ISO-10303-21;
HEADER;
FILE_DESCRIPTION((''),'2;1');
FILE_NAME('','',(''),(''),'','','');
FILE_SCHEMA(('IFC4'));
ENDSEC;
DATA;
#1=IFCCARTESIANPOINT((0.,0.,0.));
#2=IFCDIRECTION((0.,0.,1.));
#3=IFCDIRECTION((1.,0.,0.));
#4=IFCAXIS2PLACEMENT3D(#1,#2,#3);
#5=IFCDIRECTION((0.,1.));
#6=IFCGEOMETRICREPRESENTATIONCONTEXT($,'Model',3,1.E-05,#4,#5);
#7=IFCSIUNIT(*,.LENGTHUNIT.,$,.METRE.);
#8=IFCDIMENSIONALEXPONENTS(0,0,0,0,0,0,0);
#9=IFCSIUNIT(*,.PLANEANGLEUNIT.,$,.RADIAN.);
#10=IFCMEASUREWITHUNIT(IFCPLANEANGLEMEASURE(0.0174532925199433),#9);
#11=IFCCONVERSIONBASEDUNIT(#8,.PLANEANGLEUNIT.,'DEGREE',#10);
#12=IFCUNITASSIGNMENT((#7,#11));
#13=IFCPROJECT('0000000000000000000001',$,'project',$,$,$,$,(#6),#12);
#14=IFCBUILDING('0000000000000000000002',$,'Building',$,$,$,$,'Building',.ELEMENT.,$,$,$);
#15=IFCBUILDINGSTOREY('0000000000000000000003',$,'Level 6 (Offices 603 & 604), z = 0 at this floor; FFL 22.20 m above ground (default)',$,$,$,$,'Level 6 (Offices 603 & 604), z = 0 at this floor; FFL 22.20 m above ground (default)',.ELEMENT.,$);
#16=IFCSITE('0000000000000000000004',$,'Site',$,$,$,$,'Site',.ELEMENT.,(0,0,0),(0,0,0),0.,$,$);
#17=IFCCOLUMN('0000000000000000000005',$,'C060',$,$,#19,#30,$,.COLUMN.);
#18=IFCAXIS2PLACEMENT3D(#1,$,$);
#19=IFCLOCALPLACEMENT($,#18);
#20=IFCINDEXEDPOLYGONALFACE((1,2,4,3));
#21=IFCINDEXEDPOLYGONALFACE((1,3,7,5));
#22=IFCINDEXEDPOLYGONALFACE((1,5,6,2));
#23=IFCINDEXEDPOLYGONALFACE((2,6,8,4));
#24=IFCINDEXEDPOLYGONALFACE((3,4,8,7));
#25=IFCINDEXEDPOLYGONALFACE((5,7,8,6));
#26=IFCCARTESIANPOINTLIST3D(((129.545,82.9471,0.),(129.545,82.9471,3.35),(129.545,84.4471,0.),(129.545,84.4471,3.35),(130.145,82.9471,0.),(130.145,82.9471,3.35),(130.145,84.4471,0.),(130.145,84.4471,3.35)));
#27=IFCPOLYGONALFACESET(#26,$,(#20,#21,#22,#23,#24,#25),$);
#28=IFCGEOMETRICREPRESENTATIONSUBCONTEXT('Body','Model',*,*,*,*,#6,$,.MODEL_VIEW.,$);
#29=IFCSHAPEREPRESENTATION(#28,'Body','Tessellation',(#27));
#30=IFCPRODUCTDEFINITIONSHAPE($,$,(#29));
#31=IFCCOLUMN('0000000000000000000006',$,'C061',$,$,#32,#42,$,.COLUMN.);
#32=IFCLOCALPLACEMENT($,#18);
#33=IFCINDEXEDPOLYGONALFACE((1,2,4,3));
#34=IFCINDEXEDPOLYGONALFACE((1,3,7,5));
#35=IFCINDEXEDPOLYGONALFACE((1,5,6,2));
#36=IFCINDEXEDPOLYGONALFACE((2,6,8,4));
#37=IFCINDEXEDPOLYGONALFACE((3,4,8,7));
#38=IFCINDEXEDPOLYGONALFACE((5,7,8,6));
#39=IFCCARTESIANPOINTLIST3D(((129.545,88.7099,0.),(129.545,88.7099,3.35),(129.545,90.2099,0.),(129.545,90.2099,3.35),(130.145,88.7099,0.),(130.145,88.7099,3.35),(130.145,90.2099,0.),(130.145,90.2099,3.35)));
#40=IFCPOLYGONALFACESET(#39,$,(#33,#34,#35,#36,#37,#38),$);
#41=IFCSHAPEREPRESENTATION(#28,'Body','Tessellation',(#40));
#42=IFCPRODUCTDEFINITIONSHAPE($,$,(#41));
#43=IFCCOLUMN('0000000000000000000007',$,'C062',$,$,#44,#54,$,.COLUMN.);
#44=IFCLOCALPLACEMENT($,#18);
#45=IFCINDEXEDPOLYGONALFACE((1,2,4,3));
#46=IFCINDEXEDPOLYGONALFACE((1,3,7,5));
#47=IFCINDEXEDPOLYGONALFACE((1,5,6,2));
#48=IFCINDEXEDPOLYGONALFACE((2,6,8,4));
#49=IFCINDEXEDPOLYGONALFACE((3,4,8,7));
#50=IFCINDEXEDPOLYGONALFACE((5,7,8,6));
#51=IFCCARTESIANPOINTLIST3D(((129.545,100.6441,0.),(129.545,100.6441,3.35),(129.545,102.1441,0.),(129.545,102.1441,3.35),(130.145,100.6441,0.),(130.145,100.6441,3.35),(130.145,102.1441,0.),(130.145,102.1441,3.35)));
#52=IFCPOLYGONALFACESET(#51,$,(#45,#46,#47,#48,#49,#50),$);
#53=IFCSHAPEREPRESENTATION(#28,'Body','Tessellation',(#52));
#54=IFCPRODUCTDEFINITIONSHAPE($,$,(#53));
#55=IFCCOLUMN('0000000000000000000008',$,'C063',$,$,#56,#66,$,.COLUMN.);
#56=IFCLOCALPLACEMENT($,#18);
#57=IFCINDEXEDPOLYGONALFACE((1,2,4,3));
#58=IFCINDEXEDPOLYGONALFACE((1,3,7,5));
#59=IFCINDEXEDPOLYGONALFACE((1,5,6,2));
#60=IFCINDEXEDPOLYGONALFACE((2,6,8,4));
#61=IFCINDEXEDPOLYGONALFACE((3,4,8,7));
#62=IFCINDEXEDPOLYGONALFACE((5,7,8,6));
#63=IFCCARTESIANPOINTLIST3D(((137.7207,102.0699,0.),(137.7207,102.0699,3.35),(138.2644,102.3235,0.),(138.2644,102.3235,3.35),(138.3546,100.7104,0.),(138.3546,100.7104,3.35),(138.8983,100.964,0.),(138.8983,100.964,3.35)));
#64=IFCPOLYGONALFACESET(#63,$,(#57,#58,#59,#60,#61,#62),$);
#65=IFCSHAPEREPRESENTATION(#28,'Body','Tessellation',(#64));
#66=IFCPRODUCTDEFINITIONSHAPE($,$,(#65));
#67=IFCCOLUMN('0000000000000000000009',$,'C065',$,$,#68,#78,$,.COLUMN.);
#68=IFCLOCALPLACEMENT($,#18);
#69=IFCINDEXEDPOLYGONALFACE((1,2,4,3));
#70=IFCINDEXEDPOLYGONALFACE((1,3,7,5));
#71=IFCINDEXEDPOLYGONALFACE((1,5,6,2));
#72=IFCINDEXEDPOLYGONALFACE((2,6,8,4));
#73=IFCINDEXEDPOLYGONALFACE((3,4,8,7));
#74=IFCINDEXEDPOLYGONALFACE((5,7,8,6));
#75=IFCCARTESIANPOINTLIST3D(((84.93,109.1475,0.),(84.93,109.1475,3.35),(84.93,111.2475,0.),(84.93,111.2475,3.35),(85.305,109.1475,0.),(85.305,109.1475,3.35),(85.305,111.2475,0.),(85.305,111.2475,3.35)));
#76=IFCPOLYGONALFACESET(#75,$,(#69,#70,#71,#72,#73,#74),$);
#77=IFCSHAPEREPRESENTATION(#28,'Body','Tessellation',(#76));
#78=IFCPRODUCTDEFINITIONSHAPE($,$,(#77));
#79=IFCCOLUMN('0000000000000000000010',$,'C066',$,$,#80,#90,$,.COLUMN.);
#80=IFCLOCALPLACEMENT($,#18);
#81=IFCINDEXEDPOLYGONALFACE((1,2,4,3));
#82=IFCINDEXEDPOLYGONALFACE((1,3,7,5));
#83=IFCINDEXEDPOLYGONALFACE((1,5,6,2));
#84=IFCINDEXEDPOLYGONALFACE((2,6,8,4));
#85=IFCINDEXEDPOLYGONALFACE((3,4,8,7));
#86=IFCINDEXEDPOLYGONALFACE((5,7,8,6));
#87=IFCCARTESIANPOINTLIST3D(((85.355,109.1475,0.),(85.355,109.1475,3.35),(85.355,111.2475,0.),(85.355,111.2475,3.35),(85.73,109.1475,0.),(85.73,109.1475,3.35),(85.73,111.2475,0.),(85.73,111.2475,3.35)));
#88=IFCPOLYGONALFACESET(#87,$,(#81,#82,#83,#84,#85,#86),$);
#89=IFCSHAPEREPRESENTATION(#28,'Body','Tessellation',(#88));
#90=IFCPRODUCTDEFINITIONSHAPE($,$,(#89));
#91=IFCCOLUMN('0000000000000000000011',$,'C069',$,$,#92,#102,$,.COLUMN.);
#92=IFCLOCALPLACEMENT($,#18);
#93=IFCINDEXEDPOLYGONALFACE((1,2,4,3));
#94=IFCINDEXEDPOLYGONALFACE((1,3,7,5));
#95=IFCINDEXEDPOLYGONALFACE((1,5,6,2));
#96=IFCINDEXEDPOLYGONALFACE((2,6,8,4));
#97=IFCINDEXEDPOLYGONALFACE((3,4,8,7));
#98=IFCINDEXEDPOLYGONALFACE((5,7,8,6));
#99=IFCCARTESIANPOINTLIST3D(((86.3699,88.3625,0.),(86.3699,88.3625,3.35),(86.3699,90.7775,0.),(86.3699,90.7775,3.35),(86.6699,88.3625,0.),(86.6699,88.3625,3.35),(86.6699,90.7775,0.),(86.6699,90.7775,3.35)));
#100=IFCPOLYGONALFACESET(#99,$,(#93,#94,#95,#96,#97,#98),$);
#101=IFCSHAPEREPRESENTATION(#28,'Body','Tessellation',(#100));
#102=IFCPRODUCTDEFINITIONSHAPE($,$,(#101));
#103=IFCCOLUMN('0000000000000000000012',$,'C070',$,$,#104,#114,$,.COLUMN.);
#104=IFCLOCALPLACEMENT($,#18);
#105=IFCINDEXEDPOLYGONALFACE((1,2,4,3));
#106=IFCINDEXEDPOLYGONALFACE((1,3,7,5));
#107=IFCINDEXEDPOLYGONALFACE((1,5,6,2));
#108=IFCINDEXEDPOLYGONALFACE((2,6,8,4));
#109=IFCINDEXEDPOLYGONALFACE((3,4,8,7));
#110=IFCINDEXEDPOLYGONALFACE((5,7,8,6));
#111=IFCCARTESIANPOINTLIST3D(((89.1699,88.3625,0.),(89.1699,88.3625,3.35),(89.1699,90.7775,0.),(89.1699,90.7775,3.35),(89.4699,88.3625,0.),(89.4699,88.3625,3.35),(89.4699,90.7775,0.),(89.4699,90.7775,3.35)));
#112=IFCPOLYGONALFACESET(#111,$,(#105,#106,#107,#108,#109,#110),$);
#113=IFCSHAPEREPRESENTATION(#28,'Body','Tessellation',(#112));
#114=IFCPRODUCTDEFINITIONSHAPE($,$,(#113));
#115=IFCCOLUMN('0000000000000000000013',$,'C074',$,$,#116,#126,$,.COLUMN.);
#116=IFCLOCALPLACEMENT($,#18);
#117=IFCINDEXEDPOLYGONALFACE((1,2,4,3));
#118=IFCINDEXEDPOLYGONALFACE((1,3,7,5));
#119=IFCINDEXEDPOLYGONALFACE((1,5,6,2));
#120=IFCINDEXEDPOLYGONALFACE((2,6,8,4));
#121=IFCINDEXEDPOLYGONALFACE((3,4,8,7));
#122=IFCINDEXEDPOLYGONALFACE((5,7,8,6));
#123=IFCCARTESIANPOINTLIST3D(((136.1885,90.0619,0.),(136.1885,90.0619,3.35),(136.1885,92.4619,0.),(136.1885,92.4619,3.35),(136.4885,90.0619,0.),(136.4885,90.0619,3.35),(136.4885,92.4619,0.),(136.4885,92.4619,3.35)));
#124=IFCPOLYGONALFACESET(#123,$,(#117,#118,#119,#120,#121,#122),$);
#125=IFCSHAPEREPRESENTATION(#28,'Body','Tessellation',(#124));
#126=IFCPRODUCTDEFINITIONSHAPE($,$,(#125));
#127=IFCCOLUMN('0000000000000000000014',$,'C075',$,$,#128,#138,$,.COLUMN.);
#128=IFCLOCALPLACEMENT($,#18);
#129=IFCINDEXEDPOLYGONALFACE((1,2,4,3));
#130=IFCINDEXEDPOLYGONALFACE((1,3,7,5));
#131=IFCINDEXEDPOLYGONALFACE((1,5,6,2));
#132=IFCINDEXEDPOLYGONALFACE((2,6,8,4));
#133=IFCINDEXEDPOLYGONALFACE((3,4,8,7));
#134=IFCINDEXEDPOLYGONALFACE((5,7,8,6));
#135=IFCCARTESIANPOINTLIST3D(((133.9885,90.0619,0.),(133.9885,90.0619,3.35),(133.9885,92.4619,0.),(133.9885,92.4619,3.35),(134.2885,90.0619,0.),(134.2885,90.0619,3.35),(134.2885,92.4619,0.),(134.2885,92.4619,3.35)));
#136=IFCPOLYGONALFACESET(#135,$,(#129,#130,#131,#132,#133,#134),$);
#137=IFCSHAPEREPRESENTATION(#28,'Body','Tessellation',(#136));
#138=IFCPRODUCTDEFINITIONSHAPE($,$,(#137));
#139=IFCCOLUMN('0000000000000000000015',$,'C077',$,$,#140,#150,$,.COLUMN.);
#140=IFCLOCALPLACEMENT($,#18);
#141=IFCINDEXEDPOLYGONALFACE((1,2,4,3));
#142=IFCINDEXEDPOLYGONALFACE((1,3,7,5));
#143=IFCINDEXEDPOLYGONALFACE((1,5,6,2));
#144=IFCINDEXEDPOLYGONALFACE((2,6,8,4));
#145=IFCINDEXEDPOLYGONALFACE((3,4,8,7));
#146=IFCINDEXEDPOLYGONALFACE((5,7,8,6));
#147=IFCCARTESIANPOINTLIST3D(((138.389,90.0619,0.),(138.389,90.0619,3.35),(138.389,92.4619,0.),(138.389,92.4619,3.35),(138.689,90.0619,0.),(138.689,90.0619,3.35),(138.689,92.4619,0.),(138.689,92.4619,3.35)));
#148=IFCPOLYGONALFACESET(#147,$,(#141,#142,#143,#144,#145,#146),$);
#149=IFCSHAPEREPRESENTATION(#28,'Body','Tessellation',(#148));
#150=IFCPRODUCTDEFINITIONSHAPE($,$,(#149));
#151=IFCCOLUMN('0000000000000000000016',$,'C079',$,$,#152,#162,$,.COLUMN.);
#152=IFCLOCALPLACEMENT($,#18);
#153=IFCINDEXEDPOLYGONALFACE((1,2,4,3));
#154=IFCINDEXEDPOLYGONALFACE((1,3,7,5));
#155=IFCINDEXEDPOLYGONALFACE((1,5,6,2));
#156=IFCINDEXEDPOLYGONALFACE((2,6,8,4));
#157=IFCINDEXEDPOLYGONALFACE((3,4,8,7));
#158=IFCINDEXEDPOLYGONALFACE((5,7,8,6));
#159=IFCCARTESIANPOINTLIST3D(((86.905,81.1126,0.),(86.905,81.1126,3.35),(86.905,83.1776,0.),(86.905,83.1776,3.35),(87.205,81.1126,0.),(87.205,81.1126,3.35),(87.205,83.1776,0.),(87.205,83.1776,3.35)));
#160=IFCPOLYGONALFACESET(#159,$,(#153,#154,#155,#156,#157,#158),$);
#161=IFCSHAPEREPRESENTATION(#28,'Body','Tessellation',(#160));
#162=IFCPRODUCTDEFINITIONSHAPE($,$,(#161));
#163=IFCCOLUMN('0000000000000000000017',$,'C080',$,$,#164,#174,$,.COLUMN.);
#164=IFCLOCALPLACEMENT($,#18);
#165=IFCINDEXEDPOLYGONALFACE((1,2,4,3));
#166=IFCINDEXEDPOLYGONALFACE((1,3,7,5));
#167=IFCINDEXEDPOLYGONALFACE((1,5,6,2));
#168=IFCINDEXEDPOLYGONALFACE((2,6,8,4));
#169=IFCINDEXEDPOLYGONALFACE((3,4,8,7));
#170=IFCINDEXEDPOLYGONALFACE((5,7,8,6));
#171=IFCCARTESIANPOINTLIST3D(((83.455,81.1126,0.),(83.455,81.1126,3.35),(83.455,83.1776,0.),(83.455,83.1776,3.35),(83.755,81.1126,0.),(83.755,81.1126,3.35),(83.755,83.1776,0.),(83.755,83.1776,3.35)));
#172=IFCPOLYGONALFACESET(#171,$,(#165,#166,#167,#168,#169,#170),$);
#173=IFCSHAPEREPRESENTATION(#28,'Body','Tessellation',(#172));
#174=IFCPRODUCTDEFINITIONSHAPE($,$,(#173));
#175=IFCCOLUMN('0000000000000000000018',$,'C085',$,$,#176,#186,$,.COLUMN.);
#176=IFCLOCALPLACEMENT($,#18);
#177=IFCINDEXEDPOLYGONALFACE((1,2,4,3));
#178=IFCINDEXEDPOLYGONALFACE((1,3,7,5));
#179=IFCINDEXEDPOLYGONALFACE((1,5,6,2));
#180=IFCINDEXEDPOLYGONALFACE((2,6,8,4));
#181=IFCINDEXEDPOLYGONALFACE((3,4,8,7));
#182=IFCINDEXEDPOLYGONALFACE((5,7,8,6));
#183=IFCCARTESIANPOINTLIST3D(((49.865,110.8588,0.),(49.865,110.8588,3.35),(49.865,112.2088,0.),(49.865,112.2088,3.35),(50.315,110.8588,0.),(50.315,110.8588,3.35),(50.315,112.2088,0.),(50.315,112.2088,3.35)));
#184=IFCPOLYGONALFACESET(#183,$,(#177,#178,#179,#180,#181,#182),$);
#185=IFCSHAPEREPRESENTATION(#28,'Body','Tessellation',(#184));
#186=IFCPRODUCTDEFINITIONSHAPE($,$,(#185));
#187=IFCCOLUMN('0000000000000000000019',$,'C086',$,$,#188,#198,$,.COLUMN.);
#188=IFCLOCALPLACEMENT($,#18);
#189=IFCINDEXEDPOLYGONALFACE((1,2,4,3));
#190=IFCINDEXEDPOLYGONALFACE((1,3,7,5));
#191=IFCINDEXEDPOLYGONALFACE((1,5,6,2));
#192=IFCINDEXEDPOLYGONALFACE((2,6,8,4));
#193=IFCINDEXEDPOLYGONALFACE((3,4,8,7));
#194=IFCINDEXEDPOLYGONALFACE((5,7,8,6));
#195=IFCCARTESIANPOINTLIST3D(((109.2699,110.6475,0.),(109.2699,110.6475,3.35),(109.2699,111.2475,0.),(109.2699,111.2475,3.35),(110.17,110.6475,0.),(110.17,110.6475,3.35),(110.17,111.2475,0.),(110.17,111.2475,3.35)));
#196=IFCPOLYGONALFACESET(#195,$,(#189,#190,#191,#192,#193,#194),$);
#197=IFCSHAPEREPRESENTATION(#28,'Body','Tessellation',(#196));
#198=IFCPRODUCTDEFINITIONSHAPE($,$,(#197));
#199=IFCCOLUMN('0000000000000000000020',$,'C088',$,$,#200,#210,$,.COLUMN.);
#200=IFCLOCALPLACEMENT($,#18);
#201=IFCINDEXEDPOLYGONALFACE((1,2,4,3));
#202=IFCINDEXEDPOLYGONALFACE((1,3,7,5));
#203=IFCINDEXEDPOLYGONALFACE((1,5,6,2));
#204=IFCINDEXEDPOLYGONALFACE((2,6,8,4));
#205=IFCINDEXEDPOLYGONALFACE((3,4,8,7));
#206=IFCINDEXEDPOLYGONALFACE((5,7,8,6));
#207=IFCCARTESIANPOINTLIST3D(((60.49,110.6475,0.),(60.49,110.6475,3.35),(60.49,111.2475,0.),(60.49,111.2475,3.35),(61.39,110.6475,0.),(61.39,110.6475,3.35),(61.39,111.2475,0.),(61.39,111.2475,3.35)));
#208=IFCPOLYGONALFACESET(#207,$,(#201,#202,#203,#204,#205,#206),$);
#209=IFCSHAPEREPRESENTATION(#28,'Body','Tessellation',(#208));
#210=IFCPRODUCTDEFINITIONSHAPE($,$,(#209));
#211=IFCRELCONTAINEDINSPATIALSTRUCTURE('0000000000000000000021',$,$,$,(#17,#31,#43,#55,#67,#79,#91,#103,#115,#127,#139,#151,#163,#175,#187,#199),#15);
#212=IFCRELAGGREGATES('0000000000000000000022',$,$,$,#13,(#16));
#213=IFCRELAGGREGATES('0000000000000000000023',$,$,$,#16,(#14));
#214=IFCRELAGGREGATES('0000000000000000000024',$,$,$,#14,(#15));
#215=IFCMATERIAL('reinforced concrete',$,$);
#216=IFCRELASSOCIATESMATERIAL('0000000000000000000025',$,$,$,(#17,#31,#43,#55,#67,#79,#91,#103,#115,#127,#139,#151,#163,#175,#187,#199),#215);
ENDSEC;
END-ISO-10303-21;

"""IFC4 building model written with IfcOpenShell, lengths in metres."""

from ifc_helpers import new_model, entity, si_unit, converted_unit, direction, frame, frame_2d, origin_with_axes, origin_2d_with_axis, place, context, subcontext, project, spatial, rectangle, extrude, material, element, save


model = new_model("IFC4")

# Units and contexts
model_context = context("Model", 3, precision=1e-05, world=origin_with_axes(), true_north=direction((0.0, 1.0)))
body_context = subcontext(model_context, "Body", "Model", "MODEL_VIEW")
ifc_project = project(units=[si_unit("LENGTHUNIT", "METRE"), converted_unit("PLANEANGLEUNIT", "DEGREE", entity("IfcPlaneAngleMeasure", 0.0174532925199433), si_unit("PLANEANGLEUNIT", "RADIAN"), dimensions=[0, 0, 0, 0, 0, 0, 0])], contexts=[model_context])

# Site, building, storey
site = spatial("IfcSite", under=ifc_project, Name="Site", LongName="Site", CompositionType="ELEMENT", RefLatitude=(0, 0, 0), RefLongitude=(0, 0, 0), RefElevation=0.0)
building = spatial("IfcBuilding", under=site, Name="Building", LongName="Building", CompositionType="ELEMENT")
storey = spatial("IfcBuildingStorey", under=building, Name="Level 6 (Offices 603 & 604), z = 0 at this floor; FFL 22.20 m above ground (default)", LongName="Level 6 (Offices 603 & 604), z = 0 at this floor; FFL 22.20 m above ground (default)", CompositionType="ELEMENT")

# Columns
ifc_material_1 = material(Name="reinforced concrete")
placement = place(None, origin_with_axes())
element("IfcColumn", 1, at=placement, inside=storey, material=ifc_material_1, Name="C060", PredefinedType="COLUMN", context=body_context, shape_type="SweptSolid", body=[
    extrude(rectangle(XDim=1.5, YDim=0.6, at=frame_2d((0.0, 0.0), x_axis=(0.0, -1.0))), frame((129.845, 83.6971, 0.0), z_axis=(0.0, 0.0, 1.0), x_axis=(1.0, 0.0, 0.0)), (0.0, 0.0, 1.0), 3.35),
])
element("IfcColumn", 2, at=placement, inside=storey, material=ifc_material_1, Name="C061", PredefinedType="COLUMN", context=body_context, shape_type="SweptSolid", body=[
    extrude(rectangle(XDim=1.5, YDim=0.6, at=frame_2d((0.0, 0.0), x_axis=(0.0, -1.0))), frame((129.845, 89.4599, 0.0), z_axis=(0.0, 0.0, 1.0), x_axis=(1.0, 0.0, 0.0)), (0.0, 0.0, 1.0), 3.35),
])
element("IfcColumn", 3, at=placement, inside=storey, material=ifc_material_1, Name="C062", PredefinedType="COLUMN", context=body_context, shape_type="SweptSolid", body=[
    extrude(rectangle(XDim=1.5, YDim=0.6, at=frame_2d((0.0, 0.0), x_axis=(0.0, -1.0))), frame((129.845, 101.3941, 0.0), z_axis=(0.0, 0.0, 1.0), x_axis=(1.0, 0.0, 0.0)), (0.0, 0.0, 1.0), 3.35),
])
element("IfcColumn", 4, at=placement, inside=storey, material=ifc_material_1, Name="C063", PredefinedType="COLUMN", context=body_context, shape_type="SweptSolid", body=[
    extrude(rectangle(XDim=1.5, YDim=0.5999, at=frame_2d((0.0, 0.0), x_axis=(-0.422593, 0.906319))), frame((138.3095, 101.5169, 0.0), z_axis=(0.0, 0.0, 1.0), x_axis=(1.0, 0.0, 0.0)), (0.0, 0.0, 1.0), 3.35),
])
element("IfcColumn", 5, at=placement, inside=storey, material=ifc_material_1, Name="C065", PredefinedType="COLUMN", context=body_context, shape_type="SweptSolid", body=[
    extrude(rectangle(XDim=0.375, YDim=2.1, at=frame_2d((0.0, 0.0), x_axis=(1.0, 0.0))), frame((85.1175, 110.1975, 0.0), z_axis=(0.0, 0.0, 1.0), x_axis=(1.0, 0.0, 0.0)), (0.0, 0.0, 1.0), 3.35),
])
element("IfcColumn", 6, at=placement, inside=storey, material=ifc_material_1, Name="C066", PredefinedType="COLUMN", context=body_context, shape_type="SweptSolid", body=[
    extrude(rectangle(XDim=0.375, YDim=2.1, at=frame_2d((0.0, 0.0), x_axis=(1.0, 0.0))), frame((85.5425, 110.1975, 0.0), z_axis=(0.0, 0.0, 1.0), x_axis=(1.0, 0.0, 0.0)), (0.0, 0.0, 1.0), 3.35),
])
element("IfcColumn", 7, at=placement, inside=storey, material=ifc_material_1, Name="C069", PredefinedType="COLUMN", context=body_context, shape_type="SweptSolid", body=[
    extrude(rectangle(XDim=0.3, YDim=2.415, at=origin_2d_with_axis()), frame((86.5199, 89.57, 0.0), z_axis=(0.0, 0.0, 1.0), x_axis=(1.0, 0.0, 0.0)), (0.0, 0.0, 1.0), 3.35),
])
element("IfcColumn", 8, at=placement, inside=storey, material=ifc_material_1, Name="C070", PredefinedType="COLUMN", context=body_context, shape_type="SweptSolid", body=[
    extrude(rectangle(XDim=2.415, YDim=0.3, at=frame_2d((0.0, 0.0), x_axis=(0.0, -1.0))), frame((89.3199, 89.57, 0.0), z_axis=(0.0, 0.0, 1.0), x_axis=(1.0, 0.0, 0.0)), (0.0, 0.0, 1.0), 3.35),
])
element("IfcColumn", 9, at=placement, inside=storey, material=ifc_material_1, Name="C074", PredefinedType="COLUMN", context=body_context, shape_type="SweptSolid", body=[
    extrude(rectangle(XDim=2.4, YDim=0.3, at=frame_2d((0.0, 0.0), x_axis=(0.0, -1.0))), frame((136.3385, 91.2619, 0.0), z_axis=(0.0, 0.0, 1.0), x_axis=(1.0, 0.0, 0.0)), (0.0, 0.0, 1.0), 3.35),
])
element("IfcColumn", 10, at=placement, inside=storey, material=ifc_material_1, Name="C075", PredefinedType="COLUMN", context=body_context, shape_type="SweptSolid", body=[
    extrude(rectangle(XDim=2.4, YDim=0.3, at=frame_2d((0.0, 0.0), x_axis=(0.0, -1.0))), frame((134.1385, 91.2619, 0.0), z_axis=(0.0, 0.0, 1.0), x_axis=(1.0, 0.0, 0.0)), (0.0, 0.0, 1.0), 3.35),
])
element("IfcColumn", 11, at=placement, inside=storey, material=ifc_material_1, Name="C077", PredefinedType="COLUMN", context=body_context, shape_type="SweptSolid", body=[
    extrude(rectangle(XDim=2.4, YDim=0.3, at=frame_2d((0.0, 0.0), x_axis=(0.0, -1.0))), frame((138.539, 91.2619, 0.0), z_axis=(0.0, 0.0, 1.0), x_axis=(1.0, 0.0, 0.0)), (0.0, 0.0, 1.0), 3.35),
])
element("IfcColumn", 12, at=placement, inside=storey, material=ifc_material_1, Name="C079", PredefinedType="COLUMN", context=body_context, shape_type="SweptSolid", body=[
    extrude(rectangle(XDim=2.065, YDim=0.3, at=frame_2d((0.0, 0.0), x_axis=(0.0, -1.0))), frame((87.055, 82.1451, 0.0), z_axis=(0.0, 0.0, 1.0), x_axis=(1.0, 0.0, 0.0)), (0.0, 0.0, 1.0), 3.35),
])
element("IfcColumn", 13, at=placement, inside=storey, material=ifc_material_1, Name="C080", PredefinedType="COLUMN", context=body_context, shape_type="SweptSolid", body=[
    extrude(rectangle(XDim=2.065, YDim=0.3, at=frame_2d((0.0, 0.0), x_axis=(0.0, -1.0))), frame((83.605, 82.1451, 0.0), z_axis=(0.0, 0.0, 1.0), x_axis=(1.0, 0.0, 0.0)), (0.0, 0.0, 1.0), 3.35),
])
element("IfcColumn", 14, at=placement, inside=storey, material=ifc_material_1, Name="C085", PredefinedType="COLUMN", context=body_context, shape_type="SweptSolid", body=[
    extrude(rectangle(XDim=0.45, YDim=1.35, at=frame_2d((0.0, 0.0), x_axis=(-1.0, 0.0))), frame((50.09, 111.5338, 0.0), z_axis=(0.0, 0.0, 1.0), x_axis=(1.0, 0.0, 0.0)), (0.0, 0.0, 1.0), 3.35),
])
element("IfcColumn", 15, at=placement, inside=storey, material=ifc_material_1, Name="C086", PredefinedType="COLUMN", context=body_context, shape_type="SweptSolid", body=[
    extrude(rectangle(XDim=0.9001, YDim=0.6, at=frame_2d((0.0, 0.0), x_axis=(-1.0, 0.0))), frame((109.7199, 110.9475, 0.0), z_axis=(0.0, 0.0, 1.0), x_axis=(1.0, 0.0, 0.0)), (0.0, 0.0, 1.0), 3.35),
])
element("IfcColumn", 16, at=placement, inside=storey, material=ifc_material_1, Name="C088", PredefinedType="COLUMN", context=body_context, shape_type="SweptSolid", body=[
    extrude(rectangle(XDim=0.9, YDim=0.6, at=frame_2d((0.0, 0.0), x_axis=(-1.0, 0.0))), frame((60.94, 110.9475, 0.0), z_axis=(0.0, 0.0, 1.0), x_axis=(1.0, 0.0, 0.0)), (0.0, 0.0, 1.0), 3.35),
])

save(model, "model.ifc")
